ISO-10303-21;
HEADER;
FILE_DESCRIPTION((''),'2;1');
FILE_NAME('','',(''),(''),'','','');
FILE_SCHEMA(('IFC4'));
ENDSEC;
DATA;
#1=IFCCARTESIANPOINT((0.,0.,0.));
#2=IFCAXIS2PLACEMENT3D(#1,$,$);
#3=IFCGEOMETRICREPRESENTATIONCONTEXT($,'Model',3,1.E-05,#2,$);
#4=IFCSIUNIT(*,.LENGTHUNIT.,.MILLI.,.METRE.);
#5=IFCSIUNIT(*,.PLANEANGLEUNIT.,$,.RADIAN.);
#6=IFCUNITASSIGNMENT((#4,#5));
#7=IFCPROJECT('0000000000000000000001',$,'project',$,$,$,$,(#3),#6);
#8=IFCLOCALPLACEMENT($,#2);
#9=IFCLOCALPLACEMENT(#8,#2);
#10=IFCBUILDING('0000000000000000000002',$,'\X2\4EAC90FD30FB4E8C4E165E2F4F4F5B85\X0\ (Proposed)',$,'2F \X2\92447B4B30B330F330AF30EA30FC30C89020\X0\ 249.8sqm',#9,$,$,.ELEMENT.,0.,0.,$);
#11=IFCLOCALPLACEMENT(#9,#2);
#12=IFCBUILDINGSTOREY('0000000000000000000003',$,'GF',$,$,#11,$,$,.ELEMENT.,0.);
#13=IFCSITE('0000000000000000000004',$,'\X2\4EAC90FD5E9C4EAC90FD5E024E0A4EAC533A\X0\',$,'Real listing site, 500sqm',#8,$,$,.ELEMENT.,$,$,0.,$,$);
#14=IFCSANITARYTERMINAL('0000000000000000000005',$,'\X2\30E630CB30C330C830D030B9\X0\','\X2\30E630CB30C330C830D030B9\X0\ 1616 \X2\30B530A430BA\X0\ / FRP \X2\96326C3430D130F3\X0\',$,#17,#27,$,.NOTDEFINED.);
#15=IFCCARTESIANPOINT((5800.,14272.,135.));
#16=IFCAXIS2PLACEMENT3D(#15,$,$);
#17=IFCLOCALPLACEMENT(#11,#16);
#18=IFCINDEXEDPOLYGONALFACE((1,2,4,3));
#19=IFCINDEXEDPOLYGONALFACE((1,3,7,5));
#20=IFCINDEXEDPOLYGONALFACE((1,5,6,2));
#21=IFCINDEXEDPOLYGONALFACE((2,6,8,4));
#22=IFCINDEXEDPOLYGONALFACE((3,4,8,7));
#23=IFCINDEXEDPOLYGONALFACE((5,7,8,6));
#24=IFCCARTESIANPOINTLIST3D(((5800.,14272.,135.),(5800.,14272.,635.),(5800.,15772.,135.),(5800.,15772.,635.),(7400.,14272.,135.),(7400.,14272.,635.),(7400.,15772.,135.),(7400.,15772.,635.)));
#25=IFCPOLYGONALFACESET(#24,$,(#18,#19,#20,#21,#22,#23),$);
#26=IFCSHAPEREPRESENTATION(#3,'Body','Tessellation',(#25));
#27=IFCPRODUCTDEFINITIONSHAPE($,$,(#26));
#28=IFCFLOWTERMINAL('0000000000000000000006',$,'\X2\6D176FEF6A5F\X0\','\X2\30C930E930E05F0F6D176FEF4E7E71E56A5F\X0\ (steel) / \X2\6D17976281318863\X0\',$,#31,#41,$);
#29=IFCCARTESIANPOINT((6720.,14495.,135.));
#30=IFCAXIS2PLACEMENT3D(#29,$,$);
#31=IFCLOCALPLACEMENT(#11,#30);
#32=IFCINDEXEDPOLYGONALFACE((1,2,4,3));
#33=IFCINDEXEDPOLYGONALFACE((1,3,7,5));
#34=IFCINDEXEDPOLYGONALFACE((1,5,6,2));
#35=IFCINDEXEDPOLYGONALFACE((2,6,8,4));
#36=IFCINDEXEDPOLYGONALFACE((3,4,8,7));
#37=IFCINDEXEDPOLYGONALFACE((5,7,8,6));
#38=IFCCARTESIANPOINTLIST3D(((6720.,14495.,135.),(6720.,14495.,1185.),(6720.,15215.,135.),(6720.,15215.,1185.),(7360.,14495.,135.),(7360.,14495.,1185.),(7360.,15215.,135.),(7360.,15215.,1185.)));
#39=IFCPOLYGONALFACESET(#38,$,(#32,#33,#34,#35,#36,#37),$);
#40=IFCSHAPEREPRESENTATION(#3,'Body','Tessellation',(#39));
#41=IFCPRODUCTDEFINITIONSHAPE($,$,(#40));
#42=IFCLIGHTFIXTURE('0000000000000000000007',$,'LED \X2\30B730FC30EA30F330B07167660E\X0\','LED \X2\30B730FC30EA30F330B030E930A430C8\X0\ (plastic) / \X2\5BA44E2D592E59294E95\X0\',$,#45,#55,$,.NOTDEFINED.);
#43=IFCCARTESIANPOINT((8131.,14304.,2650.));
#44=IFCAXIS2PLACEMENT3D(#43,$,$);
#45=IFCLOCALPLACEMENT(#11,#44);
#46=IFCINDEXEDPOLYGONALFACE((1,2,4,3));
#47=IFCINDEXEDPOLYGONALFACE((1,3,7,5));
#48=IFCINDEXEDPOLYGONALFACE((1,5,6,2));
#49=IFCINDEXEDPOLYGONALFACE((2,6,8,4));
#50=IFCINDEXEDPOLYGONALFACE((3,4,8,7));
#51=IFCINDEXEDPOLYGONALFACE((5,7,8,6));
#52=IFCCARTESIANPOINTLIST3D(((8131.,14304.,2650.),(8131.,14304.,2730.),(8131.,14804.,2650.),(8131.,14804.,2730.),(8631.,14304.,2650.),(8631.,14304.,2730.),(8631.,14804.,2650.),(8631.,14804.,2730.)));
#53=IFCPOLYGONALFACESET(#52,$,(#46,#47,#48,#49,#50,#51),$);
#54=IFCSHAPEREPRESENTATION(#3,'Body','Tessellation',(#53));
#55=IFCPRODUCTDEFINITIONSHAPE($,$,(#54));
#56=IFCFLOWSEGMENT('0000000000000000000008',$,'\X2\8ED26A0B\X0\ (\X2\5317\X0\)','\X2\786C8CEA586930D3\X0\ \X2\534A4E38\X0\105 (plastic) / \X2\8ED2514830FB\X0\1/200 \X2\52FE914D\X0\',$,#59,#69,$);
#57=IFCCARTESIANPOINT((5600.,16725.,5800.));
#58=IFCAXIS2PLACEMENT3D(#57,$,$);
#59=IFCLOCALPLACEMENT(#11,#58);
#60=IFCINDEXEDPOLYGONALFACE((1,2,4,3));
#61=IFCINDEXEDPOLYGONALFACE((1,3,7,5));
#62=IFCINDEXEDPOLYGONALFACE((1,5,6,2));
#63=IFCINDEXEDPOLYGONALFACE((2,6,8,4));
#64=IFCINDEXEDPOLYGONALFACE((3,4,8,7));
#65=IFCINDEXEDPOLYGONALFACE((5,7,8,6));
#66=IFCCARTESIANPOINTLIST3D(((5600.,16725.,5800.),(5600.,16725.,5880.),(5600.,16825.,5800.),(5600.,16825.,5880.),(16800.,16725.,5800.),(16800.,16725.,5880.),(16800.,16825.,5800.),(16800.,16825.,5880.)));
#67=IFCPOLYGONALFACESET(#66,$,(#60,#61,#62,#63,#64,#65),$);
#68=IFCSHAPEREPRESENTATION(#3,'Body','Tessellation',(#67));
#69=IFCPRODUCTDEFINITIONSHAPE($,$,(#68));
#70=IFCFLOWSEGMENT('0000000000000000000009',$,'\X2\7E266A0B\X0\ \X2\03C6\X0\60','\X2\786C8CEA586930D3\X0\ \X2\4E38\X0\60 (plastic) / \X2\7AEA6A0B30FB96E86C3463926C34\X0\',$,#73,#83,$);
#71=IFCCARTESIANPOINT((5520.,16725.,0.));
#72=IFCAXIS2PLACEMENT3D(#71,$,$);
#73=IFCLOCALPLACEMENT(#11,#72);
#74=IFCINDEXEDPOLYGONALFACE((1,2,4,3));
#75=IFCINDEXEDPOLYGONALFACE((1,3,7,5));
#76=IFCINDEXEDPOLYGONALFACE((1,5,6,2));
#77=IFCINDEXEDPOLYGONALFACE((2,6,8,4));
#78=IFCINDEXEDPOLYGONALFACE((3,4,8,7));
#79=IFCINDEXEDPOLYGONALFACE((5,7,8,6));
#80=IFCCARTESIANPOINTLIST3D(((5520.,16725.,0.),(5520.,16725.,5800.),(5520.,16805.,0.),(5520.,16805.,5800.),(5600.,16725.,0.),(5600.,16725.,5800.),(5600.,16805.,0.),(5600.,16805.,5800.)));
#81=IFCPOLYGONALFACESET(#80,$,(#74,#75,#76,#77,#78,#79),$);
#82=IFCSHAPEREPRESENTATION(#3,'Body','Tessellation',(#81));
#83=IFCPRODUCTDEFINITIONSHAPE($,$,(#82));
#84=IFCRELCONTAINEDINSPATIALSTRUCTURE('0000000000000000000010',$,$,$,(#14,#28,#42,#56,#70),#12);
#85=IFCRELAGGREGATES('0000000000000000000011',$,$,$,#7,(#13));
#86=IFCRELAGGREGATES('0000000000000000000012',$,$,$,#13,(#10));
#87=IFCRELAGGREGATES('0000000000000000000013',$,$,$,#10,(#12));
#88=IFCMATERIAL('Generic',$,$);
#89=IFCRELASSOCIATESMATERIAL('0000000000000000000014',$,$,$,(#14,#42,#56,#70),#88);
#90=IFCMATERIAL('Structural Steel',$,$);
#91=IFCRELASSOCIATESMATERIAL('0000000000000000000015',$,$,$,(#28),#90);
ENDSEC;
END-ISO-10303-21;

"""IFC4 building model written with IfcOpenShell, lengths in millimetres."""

from ifc_helpers import new_model, si_unit, frame, frame_2d, origin, place, context, project, spatial, rectangle, extrude, material, element, save


model = new_model("IFC4")

# Units and contexts
model_context = context("Model", 3, precision=1e-05, world=origin())
ifc_project = project(units=[si_unit("LENGTHUNIT", "METRE", prefix="MILLI"), si_unit("PLANEANGLEUNIT", "RADIAN")], contexts=[model_context])

# Site, building, storey
site_placement = place(None, origin())
site = spatial("IfcSite", under=ifc_project, at=site_placement, Name="京都府京都市上京区", ObjectType="Real listing site, 500sqm", CompositionType="ELEMENT", RefElevation=0.0)
building_placement = place(site_placement, origin())
building = spatial("IfcBuilding", under=site, at=building_placement, Name="京都・二世帯住宅 (Proposed)", ObjectType="2F 鉄筋コンクリート造 249.8sqm", CompositionType="ELEMENT", ElevationOfRefHeight=0.0, ElevationOfTerrain=0.0)
storey_placement = place(building_placement, origin())
storey = spatial("IfcBuildingStorey", under=building, at=storey_placement, Name="GF", CompositionType="ELEMENT", Elevation=0.0)

# Sanitary terminal
ifc_material_1 = material(Name="Generic")
sanitary_terminal_placement = place(storey_placement, frame((5800.0, 14272.0, 135.0)))
element("IfcSanitaryTerminal", 1, at=sanitary_terminal_placement, inside=storey, material=ifc_material_1, Name="ユニットバス", Description="ユニットバス 1616 サイズ / FRP 防水パン", PredefinedType="NOTDEFINED", context=model_context, shape_type="SweptSolid", body=[
    extrude(rectangle(XDim=1600.0, YDim=1500.0, at=frame_2d((800.0, 750.0))), frame((5800.0, 14272.0, 135.0)), (0.0, 0.0, 1.0), 500.0),
])

# Flow terminal
ifc_material_2 = material(Name="Structural Steel")
flow_terminal_placement = place(storey_placement, frame((6720.0, 14495.0, 135.0)))
element("IfcFlowTerminal", 2, at=flow_terminal_placement, inside=storey, material=ifc_material_2, Name="洗濯機", Description="ドラム式洗濯乾燥機 (steel) / 洗面脱衣", context=model_context, shape_type="SweptSolid", body=[
    extrude(rectangle(XDim=640.0, YDim=720.0, at=frame_2d((320.0, 360.0))), frame((6720.0, 14495.0, 135.0)), (0.0, 0.0, 1.0), 1050.0),
])

# Light fixture
light_fixture_placement = place(storey_placement, frame((8131.0, 14304.0, 2650.0)))
element("IfcLightFixture", 3, at=light_fixture_placement, inside=storey, material=ifc_material_1, Name="LED シーリング照明", Description="LED シーリングライト (plastic) / 室中央天井", PredefinedType="NOTDEFINED", context=model_context, shape_type="SweptSolid", body=[
    extrude(rectangle(XDim=500.0, YDim=500.0, at=frame_2d((250.0, 250.0))), frame((8131.0, 14304.0, 2650.0)), (0.0, 0.0, 1.0), 80.0),
])

# Flow segments
flow_segment_1_placement = place(storey_placement, frame((5600.0, 16725.0, 5800.0)))
element("IfcFlowSegment", 4, at=flow_segment_1_placement, inside=storey, material=ifc_material_1, Name="軒樋 (北)", Description="硬質塩ビ 半丸105 (plastic) / 軒先・1/200 勾配", context=model_context, shape_type="SweptSolid", body=[
    extrude(rectangle(XDim=11200.0, YDim=100.0, at=frame_2d((5600.0, 50.0))), frame((5600.0, 16725.0, 5800.0)), (0.0, 0.0, 1.0), 80.0),
])
flow_segment_2_placement = place(storey_placement, frame((5520.0, 16725.0, 0.0)))
element("IfcFlowSegment", 5, at=flow_segment_2_placement, inside=storey, material=ifc_material_1, Name="縦樋 φ60", Description="硬質塩ビ 丸60 (plastic) / 竪樋・雨水排水", context=model_context, shape_type="SweptSolid", body=[
    extrude(rectangle(XDim=80.0, YDim=80.0, at=frame_2d((40.0, 40.0))), frame((5520.0, 16725.0, 0.0)), (0.0, 0.0, 1.0), 5800.0),
])

save(model, "model.ifc")
